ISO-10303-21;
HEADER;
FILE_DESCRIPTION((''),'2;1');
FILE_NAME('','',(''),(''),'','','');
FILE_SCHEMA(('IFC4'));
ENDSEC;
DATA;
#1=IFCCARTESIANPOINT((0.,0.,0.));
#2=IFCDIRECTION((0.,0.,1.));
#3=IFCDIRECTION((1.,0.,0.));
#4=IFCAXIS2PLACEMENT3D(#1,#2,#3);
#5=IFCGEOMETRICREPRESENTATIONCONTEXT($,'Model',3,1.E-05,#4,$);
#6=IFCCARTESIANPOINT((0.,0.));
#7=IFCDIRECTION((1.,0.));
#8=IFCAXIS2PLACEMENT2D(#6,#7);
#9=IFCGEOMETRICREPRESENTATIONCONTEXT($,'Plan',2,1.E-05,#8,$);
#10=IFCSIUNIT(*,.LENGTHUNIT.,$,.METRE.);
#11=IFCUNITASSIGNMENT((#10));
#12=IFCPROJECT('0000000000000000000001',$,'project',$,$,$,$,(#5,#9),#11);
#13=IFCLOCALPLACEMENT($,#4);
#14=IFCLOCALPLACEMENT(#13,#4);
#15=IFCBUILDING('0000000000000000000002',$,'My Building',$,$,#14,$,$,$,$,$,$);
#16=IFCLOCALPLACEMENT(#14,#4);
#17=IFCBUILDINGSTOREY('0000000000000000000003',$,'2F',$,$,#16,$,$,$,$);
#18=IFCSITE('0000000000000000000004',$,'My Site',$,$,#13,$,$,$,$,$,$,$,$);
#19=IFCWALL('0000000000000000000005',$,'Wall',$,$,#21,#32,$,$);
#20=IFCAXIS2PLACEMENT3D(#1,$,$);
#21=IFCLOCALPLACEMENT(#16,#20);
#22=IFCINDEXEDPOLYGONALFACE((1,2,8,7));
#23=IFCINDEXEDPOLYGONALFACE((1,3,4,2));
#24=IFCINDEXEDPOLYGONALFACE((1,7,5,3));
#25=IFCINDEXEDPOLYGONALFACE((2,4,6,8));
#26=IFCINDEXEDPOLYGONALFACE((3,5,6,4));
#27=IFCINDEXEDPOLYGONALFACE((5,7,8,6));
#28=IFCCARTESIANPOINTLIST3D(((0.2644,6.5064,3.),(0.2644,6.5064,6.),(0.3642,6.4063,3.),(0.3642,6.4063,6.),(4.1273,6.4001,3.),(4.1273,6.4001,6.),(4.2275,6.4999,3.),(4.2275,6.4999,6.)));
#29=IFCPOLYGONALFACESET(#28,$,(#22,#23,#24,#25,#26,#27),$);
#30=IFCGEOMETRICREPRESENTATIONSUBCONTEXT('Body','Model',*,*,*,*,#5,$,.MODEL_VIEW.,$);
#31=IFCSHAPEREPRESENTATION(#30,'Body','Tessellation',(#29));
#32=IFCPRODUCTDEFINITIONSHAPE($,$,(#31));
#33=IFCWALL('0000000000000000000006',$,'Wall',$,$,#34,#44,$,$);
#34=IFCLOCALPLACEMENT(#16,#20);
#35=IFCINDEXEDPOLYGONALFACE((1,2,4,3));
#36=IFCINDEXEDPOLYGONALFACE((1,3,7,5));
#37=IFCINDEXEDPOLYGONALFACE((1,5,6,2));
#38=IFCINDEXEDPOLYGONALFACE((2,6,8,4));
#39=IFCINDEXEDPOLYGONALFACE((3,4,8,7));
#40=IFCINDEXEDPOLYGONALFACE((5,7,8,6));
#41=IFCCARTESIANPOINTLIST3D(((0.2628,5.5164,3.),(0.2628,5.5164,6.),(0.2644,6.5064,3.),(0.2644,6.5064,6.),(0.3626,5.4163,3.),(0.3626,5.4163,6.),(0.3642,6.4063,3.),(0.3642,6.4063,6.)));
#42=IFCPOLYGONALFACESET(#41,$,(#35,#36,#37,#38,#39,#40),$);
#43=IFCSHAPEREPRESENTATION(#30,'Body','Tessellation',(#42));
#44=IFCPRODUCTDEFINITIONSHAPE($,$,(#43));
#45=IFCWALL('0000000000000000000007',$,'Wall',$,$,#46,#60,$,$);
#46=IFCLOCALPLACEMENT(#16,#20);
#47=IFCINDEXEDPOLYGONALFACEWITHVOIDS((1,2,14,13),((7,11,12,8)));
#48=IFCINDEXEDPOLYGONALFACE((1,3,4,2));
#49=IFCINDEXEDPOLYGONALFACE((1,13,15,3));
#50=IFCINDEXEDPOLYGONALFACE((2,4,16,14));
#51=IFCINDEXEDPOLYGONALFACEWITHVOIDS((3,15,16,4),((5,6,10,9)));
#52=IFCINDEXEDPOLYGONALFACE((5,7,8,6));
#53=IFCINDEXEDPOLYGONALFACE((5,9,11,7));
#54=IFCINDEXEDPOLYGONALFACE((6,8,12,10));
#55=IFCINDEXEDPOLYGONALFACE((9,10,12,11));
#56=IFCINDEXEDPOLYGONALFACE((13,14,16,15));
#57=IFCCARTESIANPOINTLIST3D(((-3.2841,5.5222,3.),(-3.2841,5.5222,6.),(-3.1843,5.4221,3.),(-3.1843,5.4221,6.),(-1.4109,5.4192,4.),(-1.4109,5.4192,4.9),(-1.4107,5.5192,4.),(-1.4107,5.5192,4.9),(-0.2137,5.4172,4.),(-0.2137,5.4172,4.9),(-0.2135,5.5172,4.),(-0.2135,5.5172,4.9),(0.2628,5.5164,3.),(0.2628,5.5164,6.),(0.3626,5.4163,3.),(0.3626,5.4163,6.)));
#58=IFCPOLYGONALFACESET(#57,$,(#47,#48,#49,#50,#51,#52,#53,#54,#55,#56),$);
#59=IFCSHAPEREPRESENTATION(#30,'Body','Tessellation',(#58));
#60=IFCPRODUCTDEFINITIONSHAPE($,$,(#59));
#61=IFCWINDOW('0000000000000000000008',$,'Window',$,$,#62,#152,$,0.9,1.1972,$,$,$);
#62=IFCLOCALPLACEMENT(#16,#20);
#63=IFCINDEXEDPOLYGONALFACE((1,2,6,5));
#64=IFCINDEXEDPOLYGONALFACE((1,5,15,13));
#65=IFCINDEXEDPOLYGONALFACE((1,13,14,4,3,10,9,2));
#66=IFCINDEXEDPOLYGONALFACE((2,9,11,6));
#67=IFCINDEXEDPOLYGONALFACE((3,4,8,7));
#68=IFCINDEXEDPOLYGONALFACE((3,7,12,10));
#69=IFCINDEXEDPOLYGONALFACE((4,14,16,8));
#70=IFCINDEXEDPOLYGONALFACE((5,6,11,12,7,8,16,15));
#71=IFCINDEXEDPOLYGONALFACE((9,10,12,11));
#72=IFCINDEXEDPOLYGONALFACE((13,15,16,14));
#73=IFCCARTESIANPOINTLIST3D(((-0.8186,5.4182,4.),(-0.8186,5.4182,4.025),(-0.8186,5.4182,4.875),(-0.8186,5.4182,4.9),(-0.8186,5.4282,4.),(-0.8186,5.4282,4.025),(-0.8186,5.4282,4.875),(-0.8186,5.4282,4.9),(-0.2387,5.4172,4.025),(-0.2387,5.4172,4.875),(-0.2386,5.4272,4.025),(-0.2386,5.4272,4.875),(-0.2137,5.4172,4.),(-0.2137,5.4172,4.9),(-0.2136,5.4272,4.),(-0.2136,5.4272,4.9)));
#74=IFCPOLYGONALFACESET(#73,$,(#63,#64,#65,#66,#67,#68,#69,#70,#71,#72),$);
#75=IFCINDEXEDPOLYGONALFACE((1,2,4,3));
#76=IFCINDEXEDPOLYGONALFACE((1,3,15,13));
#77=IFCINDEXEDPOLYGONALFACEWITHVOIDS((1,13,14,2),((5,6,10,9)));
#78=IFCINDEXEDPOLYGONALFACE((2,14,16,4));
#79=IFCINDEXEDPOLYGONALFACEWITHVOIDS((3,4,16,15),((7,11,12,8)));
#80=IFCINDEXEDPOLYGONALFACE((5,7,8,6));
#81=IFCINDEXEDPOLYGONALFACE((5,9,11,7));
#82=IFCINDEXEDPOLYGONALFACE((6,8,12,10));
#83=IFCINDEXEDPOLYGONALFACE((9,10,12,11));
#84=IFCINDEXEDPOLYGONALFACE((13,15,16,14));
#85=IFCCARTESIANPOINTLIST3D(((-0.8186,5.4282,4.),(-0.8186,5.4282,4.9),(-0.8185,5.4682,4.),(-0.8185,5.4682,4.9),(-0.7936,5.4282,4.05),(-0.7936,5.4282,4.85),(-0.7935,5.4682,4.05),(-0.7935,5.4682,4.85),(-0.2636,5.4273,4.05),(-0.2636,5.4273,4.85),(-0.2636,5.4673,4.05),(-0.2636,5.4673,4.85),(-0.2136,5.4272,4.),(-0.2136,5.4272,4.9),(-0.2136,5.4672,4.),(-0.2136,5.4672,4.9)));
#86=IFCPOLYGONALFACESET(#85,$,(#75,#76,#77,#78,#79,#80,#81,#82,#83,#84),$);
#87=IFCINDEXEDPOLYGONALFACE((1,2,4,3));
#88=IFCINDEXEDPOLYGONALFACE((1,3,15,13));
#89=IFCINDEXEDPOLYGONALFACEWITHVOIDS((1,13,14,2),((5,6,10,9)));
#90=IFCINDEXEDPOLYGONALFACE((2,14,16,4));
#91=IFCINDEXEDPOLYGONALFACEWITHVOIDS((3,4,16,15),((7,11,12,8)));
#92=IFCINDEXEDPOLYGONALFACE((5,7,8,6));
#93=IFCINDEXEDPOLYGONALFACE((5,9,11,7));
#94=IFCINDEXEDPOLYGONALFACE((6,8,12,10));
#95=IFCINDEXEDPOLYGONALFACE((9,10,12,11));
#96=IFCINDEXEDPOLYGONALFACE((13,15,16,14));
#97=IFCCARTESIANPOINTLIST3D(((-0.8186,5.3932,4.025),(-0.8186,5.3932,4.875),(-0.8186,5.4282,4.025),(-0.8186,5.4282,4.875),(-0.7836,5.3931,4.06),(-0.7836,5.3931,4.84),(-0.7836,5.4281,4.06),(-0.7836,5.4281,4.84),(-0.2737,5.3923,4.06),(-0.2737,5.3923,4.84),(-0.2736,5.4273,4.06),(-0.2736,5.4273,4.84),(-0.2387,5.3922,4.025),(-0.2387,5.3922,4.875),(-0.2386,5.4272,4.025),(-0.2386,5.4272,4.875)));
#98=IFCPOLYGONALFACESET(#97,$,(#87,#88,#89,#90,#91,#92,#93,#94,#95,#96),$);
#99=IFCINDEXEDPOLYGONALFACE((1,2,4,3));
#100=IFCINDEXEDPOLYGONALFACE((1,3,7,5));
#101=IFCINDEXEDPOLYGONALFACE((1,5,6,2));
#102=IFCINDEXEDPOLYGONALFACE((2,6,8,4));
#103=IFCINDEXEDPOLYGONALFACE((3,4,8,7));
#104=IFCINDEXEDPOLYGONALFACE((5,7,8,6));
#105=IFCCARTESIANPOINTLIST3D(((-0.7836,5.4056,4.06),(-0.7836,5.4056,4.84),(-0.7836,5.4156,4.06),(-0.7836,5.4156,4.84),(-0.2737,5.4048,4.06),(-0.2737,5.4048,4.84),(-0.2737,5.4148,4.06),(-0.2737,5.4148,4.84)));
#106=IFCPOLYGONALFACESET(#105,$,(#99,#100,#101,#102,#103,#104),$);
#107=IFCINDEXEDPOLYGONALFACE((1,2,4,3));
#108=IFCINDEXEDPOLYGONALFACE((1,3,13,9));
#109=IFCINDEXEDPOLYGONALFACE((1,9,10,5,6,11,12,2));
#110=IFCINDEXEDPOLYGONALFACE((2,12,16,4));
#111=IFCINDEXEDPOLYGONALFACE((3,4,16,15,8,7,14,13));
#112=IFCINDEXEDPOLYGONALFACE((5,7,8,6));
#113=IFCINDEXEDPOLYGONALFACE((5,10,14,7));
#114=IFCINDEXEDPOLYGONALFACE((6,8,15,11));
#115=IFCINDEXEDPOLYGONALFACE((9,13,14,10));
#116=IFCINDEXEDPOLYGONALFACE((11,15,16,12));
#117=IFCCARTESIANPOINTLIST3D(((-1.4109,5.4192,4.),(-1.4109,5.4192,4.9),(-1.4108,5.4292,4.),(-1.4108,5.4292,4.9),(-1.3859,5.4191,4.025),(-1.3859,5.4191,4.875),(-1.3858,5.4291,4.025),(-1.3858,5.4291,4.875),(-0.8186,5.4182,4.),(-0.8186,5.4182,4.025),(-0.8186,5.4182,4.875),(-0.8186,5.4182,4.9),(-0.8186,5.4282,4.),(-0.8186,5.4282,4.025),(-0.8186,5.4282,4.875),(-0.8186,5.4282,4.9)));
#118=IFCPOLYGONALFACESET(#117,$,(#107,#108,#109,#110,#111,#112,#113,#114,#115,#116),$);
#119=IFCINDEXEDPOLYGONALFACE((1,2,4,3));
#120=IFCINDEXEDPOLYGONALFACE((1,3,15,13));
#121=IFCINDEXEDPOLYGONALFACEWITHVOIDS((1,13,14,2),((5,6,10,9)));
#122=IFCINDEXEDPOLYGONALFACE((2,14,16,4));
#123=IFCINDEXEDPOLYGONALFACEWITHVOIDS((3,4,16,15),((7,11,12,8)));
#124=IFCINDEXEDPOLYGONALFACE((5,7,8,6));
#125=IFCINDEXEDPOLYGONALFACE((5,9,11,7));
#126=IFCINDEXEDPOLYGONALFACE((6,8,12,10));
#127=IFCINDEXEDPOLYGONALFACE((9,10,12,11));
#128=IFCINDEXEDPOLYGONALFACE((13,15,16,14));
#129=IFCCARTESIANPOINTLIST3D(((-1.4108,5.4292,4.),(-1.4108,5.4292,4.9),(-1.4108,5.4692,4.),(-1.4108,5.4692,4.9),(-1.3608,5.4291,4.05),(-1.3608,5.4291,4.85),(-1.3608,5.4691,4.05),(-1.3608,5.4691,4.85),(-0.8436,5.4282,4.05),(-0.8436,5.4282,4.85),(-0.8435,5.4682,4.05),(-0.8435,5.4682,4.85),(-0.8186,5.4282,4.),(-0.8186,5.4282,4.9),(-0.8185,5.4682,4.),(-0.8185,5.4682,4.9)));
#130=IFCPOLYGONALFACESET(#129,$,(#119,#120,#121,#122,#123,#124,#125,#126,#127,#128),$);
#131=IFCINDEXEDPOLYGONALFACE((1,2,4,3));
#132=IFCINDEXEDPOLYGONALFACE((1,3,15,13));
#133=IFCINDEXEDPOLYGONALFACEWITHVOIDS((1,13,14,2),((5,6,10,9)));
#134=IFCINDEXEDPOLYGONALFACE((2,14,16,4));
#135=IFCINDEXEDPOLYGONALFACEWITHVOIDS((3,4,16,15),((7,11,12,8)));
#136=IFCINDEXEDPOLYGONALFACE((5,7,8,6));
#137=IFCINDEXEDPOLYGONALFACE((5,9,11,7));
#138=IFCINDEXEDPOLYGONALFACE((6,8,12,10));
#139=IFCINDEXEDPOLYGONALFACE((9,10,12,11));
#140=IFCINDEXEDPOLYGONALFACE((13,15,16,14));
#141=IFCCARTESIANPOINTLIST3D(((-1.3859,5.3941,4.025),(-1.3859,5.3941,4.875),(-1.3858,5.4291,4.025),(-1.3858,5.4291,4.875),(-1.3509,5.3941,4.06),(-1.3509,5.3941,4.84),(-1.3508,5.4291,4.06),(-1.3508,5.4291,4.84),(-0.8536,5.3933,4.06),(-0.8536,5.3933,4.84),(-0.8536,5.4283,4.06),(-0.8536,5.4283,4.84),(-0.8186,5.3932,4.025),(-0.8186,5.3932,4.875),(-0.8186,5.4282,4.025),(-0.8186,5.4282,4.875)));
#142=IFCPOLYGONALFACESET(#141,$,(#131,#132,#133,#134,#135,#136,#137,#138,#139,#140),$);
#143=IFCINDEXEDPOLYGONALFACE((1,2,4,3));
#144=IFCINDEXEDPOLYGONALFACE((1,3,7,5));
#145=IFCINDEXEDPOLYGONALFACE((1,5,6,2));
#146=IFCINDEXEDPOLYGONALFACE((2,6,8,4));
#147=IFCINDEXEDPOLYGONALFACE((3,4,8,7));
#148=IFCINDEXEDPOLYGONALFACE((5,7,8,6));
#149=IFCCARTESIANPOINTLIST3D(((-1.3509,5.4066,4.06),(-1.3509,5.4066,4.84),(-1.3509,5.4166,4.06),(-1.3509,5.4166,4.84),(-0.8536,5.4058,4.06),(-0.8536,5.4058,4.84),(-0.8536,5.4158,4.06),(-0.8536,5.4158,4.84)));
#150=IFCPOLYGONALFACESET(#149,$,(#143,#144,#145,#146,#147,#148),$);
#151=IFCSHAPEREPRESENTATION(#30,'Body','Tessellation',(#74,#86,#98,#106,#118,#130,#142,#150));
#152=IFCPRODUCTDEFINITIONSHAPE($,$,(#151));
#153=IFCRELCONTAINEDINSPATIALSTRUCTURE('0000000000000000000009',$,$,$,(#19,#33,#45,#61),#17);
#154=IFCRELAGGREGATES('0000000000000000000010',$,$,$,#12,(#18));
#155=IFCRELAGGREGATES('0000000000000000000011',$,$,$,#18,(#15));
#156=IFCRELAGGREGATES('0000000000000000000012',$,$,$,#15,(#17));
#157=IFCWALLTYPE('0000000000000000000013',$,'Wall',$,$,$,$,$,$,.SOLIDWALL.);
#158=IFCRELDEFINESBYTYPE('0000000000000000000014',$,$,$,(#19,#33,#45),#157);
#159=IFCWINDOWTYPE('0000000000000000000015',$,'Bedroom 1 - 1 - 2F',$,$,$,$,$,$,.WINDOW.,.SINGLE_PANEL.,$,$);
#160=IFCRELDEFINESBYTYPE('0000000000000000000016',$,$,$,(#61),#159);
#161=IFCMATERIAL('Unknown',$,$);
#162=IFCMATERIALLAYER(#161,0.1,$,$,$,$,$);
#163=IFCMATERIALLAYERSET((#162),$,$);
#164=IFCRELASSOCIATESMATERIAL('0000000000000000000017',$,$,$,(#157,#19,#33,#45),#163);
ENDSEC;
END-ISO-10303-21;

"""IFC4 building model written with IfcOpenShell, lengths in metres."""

from ifc_helpers import new_model, entity, si_unit, frame, origin_with_axes, origin_2d_with_axis, place, context, subcontext, project, spatial, line, indexed_curve, outline, extrude, shape, source, transform, mapped, material, layer, layer_set, layer_usage, type_object, type_shapes, element, fill, save


model = new_model("IFC4")

# Units and contexts
model_context = context("Model", 3, precision=1e-05, world=origin_with_axes())
plan_context = context("Plan", 2, precision=1e-05, world=origin_2d_with_axis())
body_context_1 = subcontext(model_context, "Body", "Model", "MODEL_VIEW")
body_context_2 = subcontext(plan_context, "Body", "Plan", "PLAN_VIEW")
ifc_project = project(units=[si_unit("LENGTHUNIT", "METRE")], contexts=[model_context, plan_context])

# Site, building, storey
site_placement = place(None, origin_with_axes())
site = spatial("IfcSite", under=ifc_project, at=site_placement, Name="My Site")
building_placement = place(site_placement, origin_with_axes())
building = spatial("IfcBuilding", under=site, at=building_placement, Name="My Building")
storey_placement = place(building_placement, origin_with_axes())
storey = spatial("IfcBuildingStorey", under=building, at=storey_placement, Name="2F")

# Shared definitions
ifc_material = material(Name="Unknown")
ifc_layer = layer(ifc_material, 0.1)
ifc_layer_set = layer_set([ifc_layer])
wall_type = type_object("IfcWallType", Name="Wall", PredefinedType="SOLIDWALL", material=ifc_layer_set)

# Walls
ifc_layer_usage_1 = layer_usage(ifc_layer_set, "AXIS2", "POSITIVE", 0.0)
wall_1_placement = place(storey_placement, frame((4.2275, 6.4999, 3.0), z_axis=(0.0, 0.0, 1.0), x_axis=(-0.999999, 0.001639, 0.0)))
element("IfcWall", 1, at=wall_1_placement, inside=storey, type_object=wall_type, material=ifc_layer_usage_1, Name="Wall", context=body_context_1, shape_type="SweptSolid", body=[
    extrude(outline(indexed_curve([(0.0, 0.0), (0.1, 0.1), (3.8631, 0.1), (3.9631, 0.0)], segments=[line(1, 2, 3, 4, 1)])), origin_with_axes(), (0.0, 0.0, 1.0), 3.0),
])
ifc_layer_usage_2 = layer_usage(ifc_layer_set, "AXIS2", "POSITIVE", 0.0)
wall_2_placement = place(storey_placement, frame((0.2644, 6.5064, 3.0), z_axis=(0.0, 0.0, 1.0), x_axis=(-0.001639, -0.999999, 0.0)))
element("IfcWall", 2, at=wall_2_placement, inside=storey, type_object=wall_type, material=ifc_layer_usage_2, Name="Wall", context=body_context_1, shape_type="SweptSolid", body=[
    extrude(outline(indexed_curve([(0.0, 0.0), (0.1, 0.1), (1.09, 0.1), (0.99, 0.0)], segments=[line(1, 2, 3, 4, 1)])), origin_with_axes(), (0.0, 0.0, 1.0), 3.0),
])

# Wall, opening, window
ifc_layer_usage_3 = layer_usage(ifc_layer_set, "AXIS2", "POSITIVE", 0.0)
wall_3_placement = place(storey_placement, frame((0.2628, 5.5164, 3.0), z_axis=(0.0, 0.0, 1.0), x_axis=(-0.999999, 0.001638, 0.0)))
wall_3 = element("IfcWall", 3, at=wall_3_placement, inside=storey, type_object=wall_type, material=ifc_layer_usage_3, Name="Wall", context=body_context_1, shape_type="SweptSolid", body=[
    extrude(outline(indexed_curve([(0.0, 0.0), (-0.1, 0.1), (3.4469, 0.1), (3.5469, 0.0)], segments=[line(1, 2, 3, 4, 1)])), origin_with_axes(), (0.0, 0.0, 1.0), 3.0),
])
shared_shape_1 = source(origin_with_axes(), body_context_1, "Body", "SweptSolid", [
    extrude(outline(indexed_curve([(0.0, 0.0), (1.1972, 0.0), (1.1972, 0.9), (0.0, 0.9)], segments=[line(1, 2, 3, 4, 1)])), frame((0.0, -0.6, 0.0), z_axis=(0.0, -1.0, 0.0), x_axis=(1.0, 0.0, 0.0)), (0.0, 0.0, -1.0), 1.2),
])
opening_1_placement = place(wall_3_placement, frame((0.4762, 0.0, 1.0), z_axis=(0.0, 0.0, 1.0), x_axis=(1.0, 0.0, 0.0)))
opening_1 = element("IfcOpeningElement", 4, at=opening_1_placement, cuts=wall_3, PredefinedType="OPENING", context=body_context_1, shape_type="MappedRepresentation", body=[
    mapped(shared_shape_1, transform((0.0, 0.0, 0.0), x_axis=(1.0, 0.0, 0.0), y_axis=(0.0, 1.0, 0.0), z_axis=(0.0, 0.0, 1.0), scale=1.0)),
])
window_type_1 = type_object("IfcWindowType", Name="Bedroom 1 - 1 - 2F", PartitioningType="SINGLE_PANEL", PredefinedType="WINDOW")
shared_shape_2 = source(origin_with_axes(), body_context_1, "Body", "SweptSolid", [
    extrude(outline(indexed_curve([(0.605, 0.0), (0.0, 0.0), (0.0, 0.9), (0.605, 0.9), (0.605, 0.875), (0.025, 0.875), (0.025, 0.025), (0.605, 0.025)], segments=[line(1, 2, 3, 4, 5, 6, 7, 8, 1)])), frame((0.0, 0.09, 0.0), z_axis=(0.0, -1.0, 0.0), x_axis=(1.0, 0.0, 0.0)), (0.0, 0.0, -1.0), 0.01),
    extrude(outline(indexed_curve([(0.0, 0.0), (0.605, 0.0), (0.605, 0.9), (0.0, 0.9)], segments=[line(1, 2, 3, 4, 1)]), holes=[indexed_curve([(0.05, 0.05), (0.58, 0.05), (0.58, 0.85), (0.05, 0.85)], segments=[line(1, 2, 3, 4, 1)])]), frame((0.0, 0.05, 0.0), z_axis=(0.0, -1.0, 0.0), x_axis=(1.0, 0.0, 0.0)), (0.0, 0.0, -1.0), 0.04),
    extrude(outline(indexed_curve([(0.0, 0.0), (0.58, 0.0), (0.58, 0.85), (0.0, 0.85)], segments=[line(1, 2, 3, 4, 1)]), holes=[indexed_curve([(0.035, 0.035), (0.545, 0.035), (0.545, 0.815), (0.035, 0.815)], segments=[line(1, 2, 3, 4, 1)])]), frame((0.025, 0.09, 0.025), z_axis=(0.0, -1.0, 0.0), x_axis=(1.0, 0.0, 0.0)), (0.0, 0.0, -1.0), 0.035),
    extrude(outline(indexed_curve([(0.035, 0.035), (0.545, 0.035), (0.545, 0.815), (0.035, 0.815)], segments=[line(1, 2, 3, 4, 1)])), frame((0.025, 0.1025, 0.025), z_axis=(0.0, -1.0, 0.0), x_axis=(1.0, 0.0, 0.0)), (0.0, 0.0, -1.0), 0.01),
    extrude(outline(indexed_curve([(0.0, 0.9), (0.5922, 0.9), (0.5922, 0.0), (0.0, 0.0), (0.0, 0.025), (0.5672, 0.025), (0.5672, 0.875), (0.0, 0.875)], segments=[line(1, 2, 3, 4, 5, 6, 7, 8, 1)])), frame((0.605, 0.09, 0.0), z_axis=(0.0, -1.0, 0.0), x_axis=(1.0, 0.0, 0.0)), (0.0, 0.0, -1.0), 0.01),
    extrude(outline(indexed_curve([(0.0, 0.0), (0.5922, 0.0), (0.5922, 0.9), (0.0, 0.9)], segments=[line(1, 2, 3, 4, 1)]), holes=[indexed_curve([(0.025, 0.05), (0.5422, 0.05), (0.5422, 0.85), (0.025, 0.85)], segments=[line(1, 2, 3, 4, 1)])]), frame((0.605, 0.05, 0.0), z_axis=(0.0, -1.0, 0.0), x_axis=(1.0, 0.0, 0.0)), (0.0, 0.0, -1.0), 0.04),
    extrude(outline(indexed_curve([(0.0, 0.0), (0.5672, 0.0), (0.5672, 0.85), (0.0, 0.85)], segments=[line(1, 2, 3, 4, 1)]), holes=[indexed_curve([(0.035, 0.035), (0.5322, 0.035), (0.5322, 0.815), (0.035, 0.815)], segments=[line(1, 2, 3, 4, 1)])]), frame((0.605, 0.09, 0.025), z_axis=(0.0, -1.0, 0.0), x_axis=(1.0, 0.0, 0.0)), (0.0, 0.0, -1.0), 0.035),
    extrude(outline(indexed_curve([(0.035, 0.035), (0.5322, 0.035), (0.5322, 0.815), (0.035, 0.815)], segments=[line(1, 2, 3, 4, 1)])), frame((0.605, 0.1025, 0.025), z_axis=(0.0, -1.0, 0.0), x_axis=(1.0, 0.0, 0.0)), (0.0, 0.0, -1.0), 0.01),
])
shared_shape_3 = source(origin_with_axes(), body_context_2, "Body", "Curve2D", [
    entity("IfcIndexedPolyCurve", entity("IfcCartesianPointList2D", [[0.05, 0.05], [0.58, 0.05]])),
    entity("IfcIndexedPolyCurve", entity("IfcCartesianPointList2D", [[0.0, 0.1], [0.025, 0.1], [0.025, 0.09], [0.05, 0.09], [0.05, 0.05], [0.0, 0.05]]), [entity("IfcLineIndex", [1, 2, 3, 4, 5, 6, 1])]),
    entity("IfcIndexedPolyCurve", entity("IfcCartesianPointList2D", [[0.605, 0.1], [0.605, 0.1], [0.605, 0.09], [0.58, 0.09], [0.58, 0.05], [0.605, 0.05]])),
    entity("IfcIndexedPolyCurve", entity("IfcCartesianPointList2D", [[0.025, 0.09], [0.06, 0.09], [0.06, 0.125], [0.025, 0.125]]), [entity("IfcLineIndex", [1, 2, 3, 4, 1])]),
    entity("IfcIndexedPolyCurve", entity("IfcCartesianPointList2D", [[0.605, 0.09], [0.57, 0.09], [0.57, 0.125], [0.605, 0.125]]), [entity("IfcLineIndex", [1, 2, 3, 4, 1])]),
    entity("IfcIndexedPolyCurve", entity("IfcCartesianPointList2D", [[0.06, 0.09], [0.57, 0.09]])),
    entity("IfcIndexedPolyCurve", entity("IfcCartesianPointList2D", [[0.06, 0.125], [0.57, 0.125]])),
    entity("IfcIndexedPolyCurve", entity("IfcCartesianPointList2D", [[0.06, 0.1075], [0.57, 0.1075]])),
    entity("IfcIndexedPolyCurve", entity("IfcCartesianPointList2D", [[0.63, 0.05], [1.1472, 0.05]])),
    entity("IfcIndexedPolyCurve", entity("IfcCartesianPointList2D", [[0.605, 0.1], [0.605, 0.1], [0.605, 0.09], [0.63, 0.09], [0.63, 0.05], [0.605, 0.05]])),
    entity("IfcIndexedPolyCurve", entity("IfcCartesianPointList2D", [[1.1972, 0.1], [1.1722, 0.1], [1.1722, 0.09], [1.1472, 0.09], [1.1472, 0.05], [1.1972, 0.05]]), [entity("IfcLineIndex", [1, 2, 3, 4, 5, 6, 1])]),
    entity("IfcIndexedPolyCurve", entity("IfcCartesianPointList2D", [[0.605, 0.09], [0.64, 0.09], [0.64, 0.125], [0.605, 0.125]]), [entity("IfcLineIndex", [1, 2, 3, 4, 1])]),
    entity("IfcIndexedPolyCurve", entity("IfcCartesianPointList2D", [[1.1722, 0.09], [1.1372, 0.09], [1.1372, 0.125], [1.1722, 0.125]]), [entity("IfcLineIndex", [1, 2, 3, 4, 1])]),
    entity("IfcIndexedPolyCurve", entity("IfcCartesianPointList2D", [[0.64, 0.09], [1.1372, 0.09]])),
    entity("IfcIndexedPolyCurve", entity("IfcCartesianPointList2D", [[0.64, 0.125], [1.1372, 0.125]])),
    entity("IfcIndexedPolyCurve", entity("IfcCartesianPointList2D", [[0.64, 0.1075], [1.1372, 0.1075]])),
])
type_shapes(window_type_1, [shared_shape_2, shared_shape_3])
window_1_placement = place(opening_1_placement, frame((0.0, 0.0, 0.0), z_axis=(0.0, 0.0, 1.0), x_axis=(1.0, 0.0, 0.0)))
window_1 = element("IfcWindow", 5, at=window_1_placement, inside=storey, type_object=window_type_1, Name="Window", OverallHeight=0.9, OverallWidth=1.1972, shapes=[
    shape(body_context_1, "Body", "MappedRepresentation", [mapped(shared_shape_2, transform((0.0, 0.0, 0.0), x_axis=(1.0, 0.0, 0.0), y_axis=(0.0, 1.0, 0.0), z_axis=(0.0, 0.0, 1.0), scale=1.0))]),
    shape(body_context_2, "Body", "MappedRepresentation", [mapped(shared_shape_3, transform((0.0, 0.0, 0.0), x_axis=(1.0, 0.0, 0.0), y_axis=(0.0, 1.0, 0.0), z_axis=(0.0, 0.0, 1.0), scale=1.0))]),
])
fill(opening_1, window_1)

save(model, "model.ifc")
